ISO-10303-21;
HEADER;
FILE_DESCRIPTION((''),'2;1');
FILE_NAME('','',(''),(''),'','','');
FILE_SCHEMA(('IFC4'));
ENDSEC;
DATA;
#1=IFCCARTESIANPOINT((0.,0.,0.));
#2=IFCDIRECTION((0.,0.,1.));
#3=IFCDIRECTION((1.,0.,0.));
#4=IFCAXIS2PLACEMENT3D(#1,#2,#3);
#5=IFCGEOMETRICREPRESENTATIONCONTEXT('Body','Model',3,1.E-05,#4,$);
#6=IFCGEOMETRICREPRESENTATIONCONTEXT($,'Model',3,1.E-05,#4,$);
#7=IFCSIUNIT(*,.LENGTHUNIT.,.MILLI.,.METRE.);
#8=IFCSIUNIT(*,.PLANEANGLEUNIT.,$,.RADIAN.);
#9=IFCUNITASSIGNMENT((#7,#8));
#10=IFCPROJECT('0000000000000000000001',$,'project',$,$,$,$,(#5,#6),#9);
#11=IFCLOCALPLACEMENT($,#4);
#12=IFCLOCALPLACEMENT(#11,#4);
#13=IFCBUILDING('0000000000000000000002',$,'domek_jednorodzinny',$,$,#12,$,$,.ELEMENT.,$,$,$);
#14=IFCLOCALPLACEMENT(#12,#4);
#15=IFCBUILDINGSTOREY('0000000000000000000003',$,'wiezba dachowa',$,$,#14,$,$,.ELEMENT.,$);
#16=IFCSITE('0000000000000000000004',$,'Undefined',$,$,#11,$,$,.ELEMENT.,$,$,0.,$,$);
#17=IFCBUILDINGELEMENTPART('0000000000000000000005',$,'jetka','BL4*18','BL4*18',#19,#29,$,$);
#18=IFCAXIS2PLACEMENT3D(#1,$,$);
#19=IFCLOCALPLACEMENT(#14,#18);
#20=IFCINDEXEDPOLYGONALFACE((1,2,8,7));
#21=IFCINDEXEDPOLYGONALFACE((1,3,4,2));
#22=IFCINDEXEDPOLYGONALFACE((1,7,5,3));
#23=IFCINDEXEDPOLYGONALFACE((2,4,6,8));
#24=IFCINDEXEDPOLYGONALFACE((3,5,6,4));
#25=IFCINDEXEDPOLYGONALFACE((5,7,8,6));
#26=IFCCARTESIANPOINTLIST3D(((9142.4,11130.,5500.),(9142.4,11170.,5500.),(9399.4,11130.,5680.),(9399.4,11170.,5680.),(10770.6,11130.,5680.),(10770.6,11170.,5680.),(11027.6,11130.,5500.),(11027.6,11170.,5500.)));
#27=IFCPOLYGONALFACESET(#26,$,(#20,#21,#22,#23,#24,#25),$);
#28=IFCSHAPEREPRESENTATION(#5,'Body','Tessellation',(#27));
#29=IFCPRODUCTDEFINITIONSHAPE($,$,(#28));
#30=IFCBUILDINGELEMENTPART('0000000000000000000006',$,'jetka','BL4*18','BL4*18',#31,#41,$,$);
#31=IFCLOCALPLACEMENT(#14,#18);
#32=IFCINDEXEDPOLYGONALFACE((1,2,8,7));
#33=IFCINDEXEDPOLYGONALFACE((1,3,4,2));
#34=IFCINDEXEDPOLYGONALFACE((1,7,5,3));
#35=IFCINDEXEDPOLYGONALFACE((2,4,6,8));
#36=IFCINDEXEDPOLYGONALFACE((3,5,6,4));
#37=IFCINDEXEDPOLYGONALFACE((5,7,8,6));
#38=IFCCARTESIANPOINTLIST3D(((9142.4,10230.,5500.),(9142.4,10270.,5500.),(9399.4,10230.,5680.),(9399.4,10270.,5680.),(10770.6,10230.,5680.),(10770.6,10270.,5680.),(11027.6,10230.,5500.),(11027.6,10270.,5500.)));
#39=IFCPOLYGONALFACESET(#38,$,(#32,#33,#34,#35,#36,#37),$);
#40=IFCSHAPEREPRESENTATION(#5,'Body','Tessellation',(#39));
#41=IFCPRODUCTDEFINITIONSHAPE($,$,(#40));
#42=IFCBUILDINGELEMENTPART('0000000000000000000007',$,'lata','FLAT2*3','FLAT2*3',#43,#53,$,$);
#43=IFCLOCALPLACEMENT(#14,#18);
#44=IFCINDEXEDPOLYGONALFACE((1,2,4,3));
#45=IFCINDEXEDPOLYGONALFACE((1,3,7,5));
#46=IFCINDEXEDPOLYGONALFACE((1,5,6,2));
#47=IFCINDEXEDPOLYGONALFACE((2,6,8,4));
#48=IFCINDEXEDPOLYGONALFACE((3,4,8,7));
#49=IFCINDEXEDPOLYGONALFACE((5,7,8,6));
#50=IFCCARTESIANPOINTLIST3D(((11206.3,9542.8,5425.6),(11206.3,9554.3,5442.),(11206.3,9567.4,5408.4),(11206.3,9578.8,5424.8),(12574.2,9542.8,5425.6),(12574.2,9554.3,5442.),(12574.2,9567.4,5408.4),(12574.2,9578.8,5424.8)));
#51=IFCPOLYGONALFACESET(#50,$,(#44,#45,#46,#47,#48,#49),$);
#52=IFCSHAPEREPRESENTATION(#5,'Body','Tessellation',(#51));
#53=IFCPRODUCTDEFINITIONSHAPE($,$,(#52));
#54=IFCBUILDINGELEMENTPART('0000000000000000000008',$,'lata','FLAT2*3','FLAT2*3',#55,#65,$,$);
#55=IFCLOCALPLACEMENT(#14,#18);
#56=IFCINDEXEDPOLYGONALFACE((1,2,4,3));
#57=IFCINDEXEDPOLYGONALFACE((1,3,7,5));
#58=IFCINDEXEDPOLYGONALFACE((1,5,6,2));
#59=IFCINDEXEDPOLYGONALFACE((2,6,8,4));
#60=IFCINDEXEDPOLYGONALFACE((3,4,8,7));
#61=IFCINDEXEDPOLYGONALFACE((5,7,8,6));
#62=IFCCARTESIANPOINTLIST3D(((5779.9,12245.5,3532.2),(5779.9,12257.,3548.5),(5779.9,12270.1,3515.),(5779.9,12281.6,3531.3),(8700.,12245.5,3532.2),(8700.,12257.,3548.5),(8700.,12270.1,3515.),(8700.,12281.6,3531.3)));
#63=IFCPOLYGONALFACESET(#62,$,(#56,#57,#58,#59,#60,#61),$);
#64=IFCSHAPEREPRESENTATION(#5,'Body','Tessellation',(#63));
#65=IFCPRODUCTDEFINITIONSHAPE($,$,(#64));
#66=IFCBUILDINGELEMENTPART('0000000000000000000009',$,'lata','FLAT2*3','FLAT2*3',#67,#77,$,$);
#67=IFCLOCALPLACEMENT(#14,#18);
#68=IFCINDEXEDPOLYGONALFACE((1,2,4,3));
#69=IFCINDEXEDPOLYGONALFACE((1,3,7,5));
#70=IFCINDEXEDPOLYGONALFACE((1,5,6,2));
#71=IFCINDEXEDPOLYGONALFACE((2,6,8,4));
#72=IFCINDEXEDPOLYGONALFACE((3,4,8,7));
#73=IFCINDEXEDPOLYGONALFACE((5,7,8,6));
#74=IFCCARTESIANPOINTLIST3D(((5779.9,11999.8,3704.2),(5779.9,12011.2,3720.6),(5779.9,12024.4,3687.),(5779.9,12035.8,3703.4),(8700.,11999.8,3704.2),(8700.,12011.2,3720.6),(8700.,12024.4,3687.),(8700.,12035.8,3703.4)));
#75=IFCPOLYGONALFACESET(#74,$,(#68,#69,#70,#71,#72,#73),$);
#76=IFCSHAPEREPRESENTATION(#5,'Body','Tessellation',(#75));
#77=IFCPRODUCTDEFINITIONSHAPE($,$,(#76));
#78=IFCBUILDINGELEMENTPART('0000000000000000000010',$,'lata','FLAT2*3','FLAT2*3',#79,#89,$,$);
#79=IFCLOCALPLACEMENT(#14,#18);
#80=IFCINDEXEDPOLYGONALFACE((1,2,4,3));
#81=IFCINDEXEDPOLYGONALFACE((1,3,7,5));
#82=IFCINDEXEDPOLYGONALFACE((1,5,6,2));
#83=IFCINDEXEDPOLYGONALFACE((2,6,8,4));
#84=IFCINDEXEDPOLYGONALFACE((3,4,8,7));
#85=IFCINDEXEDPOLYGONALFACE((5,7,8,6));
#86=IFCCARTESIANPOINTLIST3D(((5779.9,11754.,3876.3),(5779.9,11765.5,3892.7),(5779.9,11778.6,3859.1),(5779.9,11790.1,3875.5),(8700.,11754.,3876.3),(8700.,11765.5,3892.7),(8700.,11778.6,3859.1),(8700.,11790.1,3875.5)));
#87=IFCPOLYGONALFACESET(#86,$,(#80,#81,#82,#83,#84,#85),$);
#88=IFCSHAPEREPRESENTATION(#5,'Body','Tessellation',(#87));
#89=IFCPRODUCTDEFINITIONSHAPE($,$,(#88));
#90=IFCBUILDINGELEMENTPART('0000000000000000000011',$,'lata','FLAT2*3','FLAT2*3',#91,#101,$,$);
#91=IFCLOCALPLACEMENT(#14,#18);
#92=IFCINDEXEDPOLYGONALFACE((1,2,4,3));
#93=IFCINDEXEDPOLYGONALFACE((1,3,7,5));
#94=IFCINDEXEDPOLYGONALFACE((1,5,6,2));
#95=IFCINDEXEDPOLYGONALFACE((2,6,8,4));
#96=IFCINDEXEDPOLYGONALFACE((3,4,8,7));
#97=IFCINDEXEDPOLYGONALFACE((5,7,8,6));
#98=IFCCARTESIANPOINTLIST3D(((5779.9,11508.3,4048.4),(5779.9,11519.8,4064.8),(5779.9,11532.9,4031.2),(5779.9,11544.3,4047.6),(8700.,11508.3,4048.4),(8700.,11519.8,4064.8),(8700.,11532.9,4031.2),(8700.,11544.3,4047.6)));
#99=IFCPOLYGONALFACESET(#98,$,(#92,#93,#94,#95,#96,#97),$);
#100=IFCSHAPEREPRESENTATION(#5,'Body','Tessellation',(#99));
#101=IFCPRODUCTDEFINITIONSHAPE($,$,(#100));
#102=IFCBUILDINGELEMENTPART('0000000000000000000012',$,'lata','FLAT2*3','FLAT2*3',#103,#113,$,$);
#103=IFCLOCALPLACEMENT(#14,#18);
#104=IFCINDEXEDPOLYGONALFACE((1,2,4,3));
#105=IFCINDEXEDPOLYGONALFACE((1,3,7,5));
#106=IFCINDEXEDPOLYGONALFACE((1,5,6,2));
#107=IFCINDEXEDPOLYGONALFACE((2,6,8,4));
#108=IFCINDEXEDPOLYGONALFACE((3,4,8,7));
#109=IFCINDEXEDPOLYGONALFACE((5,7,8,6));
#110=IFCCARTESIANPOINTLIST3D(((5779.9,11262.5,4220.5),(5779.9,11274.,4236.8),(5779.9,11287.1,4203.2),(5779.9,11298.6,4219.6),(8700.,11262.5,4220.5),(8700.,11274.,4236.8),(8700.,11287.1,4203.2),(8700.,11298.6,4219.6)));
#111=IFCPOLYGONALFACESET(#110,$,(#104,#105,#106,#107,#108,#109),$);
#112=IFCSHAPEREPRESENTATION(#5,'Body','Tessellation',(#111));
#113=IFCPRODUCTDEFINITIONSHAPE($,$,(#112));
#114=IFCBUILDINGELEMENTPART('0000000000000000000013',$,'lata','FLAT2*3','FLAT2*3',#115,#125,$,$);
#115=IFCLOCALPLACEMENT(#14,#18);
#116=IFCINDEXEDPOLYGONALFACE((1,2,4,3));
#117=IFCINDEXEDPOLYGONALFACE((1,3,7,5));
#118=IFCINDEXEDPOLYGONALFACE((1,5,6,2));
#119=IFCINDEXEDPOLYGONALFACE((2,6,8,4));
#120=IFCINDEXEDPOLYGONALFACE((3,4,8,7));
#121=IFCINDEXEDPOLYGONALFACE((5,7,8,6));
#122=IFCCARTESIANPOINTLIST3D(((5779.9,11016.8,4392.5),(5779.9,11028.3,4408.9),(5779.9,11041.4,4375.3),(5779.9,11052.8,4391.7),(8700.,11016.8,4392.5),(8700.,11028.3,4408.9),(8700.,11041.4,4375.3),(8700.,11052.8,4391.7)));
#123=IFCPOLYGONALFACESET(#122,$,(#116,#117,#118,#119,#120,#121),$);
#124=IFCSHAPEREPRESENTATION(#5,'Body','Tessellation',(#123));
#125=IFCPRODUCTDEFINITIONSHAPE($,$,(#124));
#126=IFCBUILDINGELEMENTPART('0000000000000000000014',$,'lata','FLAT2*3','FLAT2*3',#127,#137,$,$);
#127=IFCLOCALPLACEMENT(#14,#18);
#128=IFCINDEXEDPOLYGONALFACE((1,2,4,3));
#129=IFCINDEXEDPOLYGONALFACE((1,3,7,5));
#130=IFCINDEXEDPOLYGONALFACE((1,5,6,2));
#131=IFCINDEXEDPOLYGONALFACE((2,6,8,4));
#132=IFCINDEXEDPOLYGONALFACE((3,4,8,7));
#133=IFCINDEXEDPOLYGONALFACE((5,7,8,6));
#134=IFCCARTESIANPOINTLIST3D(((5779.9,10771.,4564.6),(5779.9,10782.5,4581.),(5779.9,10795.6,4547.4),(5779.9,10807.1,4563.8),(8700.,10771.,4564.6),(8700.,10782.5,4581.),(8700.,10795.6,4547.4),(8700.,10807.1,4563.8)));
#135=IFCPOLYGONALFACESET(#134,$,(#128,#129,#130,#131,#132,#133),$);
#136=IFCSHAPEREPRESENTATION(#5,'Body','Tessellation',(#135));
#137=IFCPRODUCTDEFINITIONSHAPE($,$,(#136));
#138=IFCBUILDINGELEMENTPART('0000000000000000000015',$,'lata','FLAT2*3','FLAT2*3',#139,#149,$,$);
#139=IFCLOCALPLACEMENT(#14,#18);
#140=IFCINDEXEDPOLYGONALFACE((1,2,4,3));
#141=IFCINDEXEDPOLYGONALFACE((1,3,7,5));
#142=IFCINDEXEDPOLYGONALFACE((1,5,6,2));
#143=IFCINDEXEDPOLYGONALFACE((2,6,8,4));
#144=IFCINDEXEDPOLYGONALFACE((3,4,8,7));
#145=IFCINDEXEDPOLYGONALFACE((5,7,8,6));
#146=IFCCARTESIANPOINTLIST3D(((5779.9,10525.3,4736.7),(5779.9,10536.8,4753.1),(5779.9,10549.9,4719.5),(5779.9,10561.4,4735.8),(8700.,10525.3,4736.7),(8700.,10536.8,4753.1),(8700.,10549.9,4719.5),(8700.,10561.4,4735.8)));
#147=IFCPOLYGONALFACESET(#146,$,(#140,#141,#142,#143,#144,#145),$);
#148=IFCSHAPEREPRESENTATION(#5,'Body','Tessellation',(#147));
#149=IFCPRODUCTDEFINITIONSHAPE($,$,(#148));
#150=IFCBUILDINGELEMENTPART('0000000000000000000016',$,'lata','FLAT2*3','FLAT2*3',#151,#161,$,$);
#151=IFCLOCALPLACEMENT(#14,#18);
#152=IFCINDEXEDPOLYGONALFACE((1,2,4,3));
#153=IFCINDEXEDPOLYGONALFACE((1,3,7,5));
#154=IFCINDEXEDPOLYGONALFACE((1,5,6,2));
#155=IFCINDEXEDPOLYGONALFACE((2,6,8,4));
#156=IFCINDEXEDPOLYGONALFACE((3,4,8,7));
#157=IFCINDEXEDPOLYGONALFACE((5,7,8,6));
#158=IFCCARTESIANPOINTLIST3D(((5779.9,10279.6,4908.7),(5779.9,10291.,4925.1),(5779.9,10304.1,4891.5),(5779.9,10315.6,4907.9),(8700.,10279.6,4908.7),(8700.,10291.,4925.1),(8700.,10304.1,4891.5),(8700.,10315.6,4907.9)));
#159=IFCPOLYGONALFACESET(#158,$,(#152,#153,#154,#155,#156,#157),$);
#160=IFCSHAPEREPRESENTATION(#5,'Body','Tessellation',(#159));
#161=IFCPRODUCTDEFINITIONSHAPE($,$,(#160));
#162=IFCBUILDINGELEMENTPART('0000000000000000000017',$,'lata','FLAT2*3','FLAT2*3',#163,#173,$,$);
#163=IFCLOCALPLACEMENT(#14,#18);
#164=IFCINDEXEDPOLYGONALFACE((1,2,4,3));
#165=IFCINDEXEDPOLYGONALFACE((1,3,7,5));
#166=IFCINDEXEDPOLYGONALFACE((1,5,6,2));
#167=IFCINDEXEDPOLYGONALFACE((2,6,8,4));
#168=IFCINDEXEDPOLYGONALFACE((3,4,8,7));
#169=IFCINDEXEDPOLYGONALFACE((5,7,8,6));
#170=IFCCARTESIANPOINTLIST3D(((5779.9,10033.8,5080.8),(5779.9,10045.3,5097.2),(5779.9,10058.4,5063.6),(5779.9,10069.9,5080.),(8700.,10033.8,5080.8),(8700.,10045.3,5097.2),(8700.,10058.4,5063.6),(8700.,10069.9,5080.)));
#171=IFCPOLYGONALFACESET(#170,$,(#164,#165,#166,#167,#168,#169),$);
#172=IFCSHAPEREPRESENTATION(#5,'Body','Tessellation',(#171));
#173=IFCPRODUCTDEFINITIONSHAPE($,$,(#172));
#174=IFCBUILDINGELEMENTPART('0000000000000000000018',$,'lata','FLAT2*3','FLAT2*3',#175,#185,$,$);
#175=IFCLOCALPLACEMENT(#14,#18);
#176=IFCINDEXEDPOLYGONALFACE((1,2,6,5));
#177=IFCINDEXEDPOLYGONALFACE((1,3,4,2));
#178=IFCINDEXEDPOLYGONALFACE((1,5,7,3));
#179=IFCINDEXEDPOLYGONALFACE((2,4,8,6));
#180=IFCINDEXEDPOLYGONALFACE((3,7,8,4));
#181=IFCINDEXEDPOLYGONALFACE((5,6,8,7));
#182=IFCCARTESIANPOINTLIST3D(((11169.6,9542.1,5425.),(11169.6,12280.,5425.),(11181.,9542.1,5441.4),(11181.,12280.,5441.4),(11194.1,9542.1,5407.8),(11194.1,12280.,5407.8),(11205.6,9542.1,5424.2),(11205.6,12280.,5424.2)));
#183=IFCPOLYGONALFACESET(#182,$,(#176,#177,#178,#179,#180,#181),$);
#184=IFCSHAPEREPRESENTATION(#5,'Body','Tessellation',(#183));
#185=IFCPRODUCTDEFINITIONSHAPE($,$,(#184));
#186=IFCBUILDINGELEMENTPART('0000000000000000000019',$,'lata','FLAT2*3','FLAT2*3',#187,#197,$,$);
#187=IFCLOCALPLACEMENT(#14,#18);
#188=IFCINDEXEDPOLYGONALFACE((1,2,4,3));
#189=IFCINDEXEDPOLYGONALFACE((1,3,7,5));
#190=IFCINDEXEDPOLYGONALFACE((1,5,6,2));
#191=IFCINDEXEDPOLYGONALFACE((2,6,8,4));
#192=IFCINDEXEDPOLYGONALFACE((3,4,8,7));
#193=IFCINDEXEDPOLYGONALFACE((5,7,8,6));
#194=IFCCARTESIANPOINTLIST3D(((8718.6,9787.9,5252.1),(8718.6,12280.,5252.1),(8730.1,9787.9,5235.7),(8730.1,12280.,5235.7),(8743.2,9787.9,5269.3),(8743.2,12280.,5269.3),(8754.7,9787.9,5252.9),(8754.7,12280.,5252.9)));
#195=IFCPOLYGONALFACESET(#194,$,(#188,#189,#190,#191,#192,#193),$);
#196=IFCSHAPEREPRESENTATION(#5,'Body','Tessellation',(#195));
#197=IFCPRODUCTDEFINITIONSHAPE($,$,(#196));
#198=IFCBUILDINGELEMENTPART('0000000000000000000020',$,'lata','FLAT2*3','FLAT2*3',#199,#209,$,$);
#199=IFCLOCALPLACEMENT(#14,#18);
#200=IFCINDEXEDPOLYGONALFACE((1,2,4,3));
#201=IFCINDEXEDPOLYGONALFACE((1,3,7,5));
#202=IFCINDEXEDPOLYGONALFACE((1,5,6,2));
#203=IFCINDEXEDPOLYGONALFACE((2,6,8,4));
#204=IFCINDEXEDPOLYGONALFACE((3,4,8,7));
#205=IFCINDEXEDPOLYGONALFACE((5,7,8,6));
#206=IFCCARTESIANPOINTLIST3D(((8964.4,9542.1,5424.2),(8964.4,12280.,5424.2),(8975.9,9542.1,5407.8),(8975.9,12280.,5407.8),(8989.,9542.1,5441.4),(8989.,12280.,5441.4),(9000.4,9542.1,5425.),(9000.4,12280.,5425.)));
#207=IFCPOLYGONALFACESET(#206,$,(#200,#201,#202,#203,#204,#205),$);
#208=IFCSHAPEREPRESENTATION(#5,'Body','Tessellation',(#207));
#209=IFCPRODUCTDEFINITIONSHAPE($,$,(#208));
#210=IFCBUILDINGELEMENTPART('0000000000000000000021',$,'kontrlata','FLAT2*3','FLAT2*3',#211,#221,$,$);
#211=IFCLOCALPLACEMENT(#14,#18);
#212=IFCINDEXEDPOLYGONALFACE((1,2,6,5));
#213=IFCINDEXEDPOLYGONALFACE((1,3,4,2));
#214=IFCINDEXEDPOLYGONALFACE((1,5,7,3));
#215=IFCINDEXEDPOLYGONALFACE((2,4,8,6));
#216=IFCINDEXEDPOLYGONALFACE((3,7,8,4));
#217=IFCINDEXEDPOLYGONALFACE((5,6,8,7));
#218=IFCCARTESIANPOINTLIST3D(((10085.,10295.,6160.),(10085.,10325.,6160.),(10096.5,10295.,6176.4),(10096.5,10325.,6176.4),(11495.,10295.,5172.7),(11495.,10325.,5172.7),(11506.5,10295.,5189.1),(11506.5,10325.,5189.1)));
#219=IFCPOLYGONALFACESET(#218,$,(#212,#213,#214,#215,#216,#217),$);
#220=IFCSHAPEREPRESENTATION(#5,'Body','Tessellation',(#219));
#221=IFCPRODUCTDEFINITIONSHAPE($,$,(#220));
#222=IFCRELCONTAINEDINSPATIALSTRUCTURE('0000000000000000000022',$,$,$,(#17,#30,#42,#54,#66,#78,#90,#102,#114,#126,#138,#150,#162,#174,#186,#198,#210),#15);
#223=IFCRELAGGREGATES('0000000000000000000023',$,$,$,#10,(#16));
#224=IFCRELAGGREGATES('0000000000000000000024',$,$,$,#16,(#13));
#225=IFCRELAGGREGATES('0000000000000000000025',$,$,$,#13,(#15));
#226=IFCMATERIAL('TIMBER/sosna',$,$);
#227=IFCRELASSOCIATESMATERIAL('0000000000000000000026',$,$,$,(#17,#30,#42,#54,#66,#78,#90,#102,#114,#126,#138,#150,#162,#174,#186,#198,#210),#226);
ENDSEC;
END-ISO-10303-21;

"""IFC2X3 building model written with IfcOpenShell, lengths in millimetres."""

from ifc_helpers import new_model, si_unit, frame, origin_with_axes, origin_2d_with_axis, place, context, project, spatial, rectangle, extrude, clip, halfspace, material, element, save


model = new_model("IFC2X3")

# Units and contexts
model_context_1 = context("Model", 3, precision=1e-05, world=origin_with_axes(), identifier="Body")
model_context_2 = context("Model", 3, precision=1e-05, world=origin_with_axes())
ifc_project = project(units=[si_unit("LENGTHUNIT", "METRE", prefix="MILLI"), si_unit("PLANEANGLEUNIT", "RADIAN")], contexts=[model_context_1, model_context_2])

# Site, building, storey
site_placement = place(None, origin_with_axes())
site = spatial("IfcSite", under=ifc_project, at=site_placement, Name="Undefined", CompositionType="ELEMENT", RefElevation=0.0)
building_placement = place(site_placement, origin_with_axes())
building = spatial("IfcBuilding", under=site, at=building_placement, Name="domek_jednorodzinny", CompositionType="ELEMENT")
storey_placement = place(building_placement, origin_with_axes())
storey = spatial("IfcBuildingStorey", under=building, at=storey_placement, Name="wiezba dachowa", CompositionType="ELEMENT")

# Building element parts
ifc_material = material(Name="TIMBER/sosna")
building_element_part_1_placement = place(storey_placement, frame((9142.4, 11150.0, 5590.0), z_axis=(0.0, 0.0, 1.0), x_axis=(1.0, 0.0, 0.0)))
element("IfcBuildingElementPart", 1, at=building_element_part_1_placement, inside=storey, material=ifc_material, Name="jetka", Description="BL4*18", ObjectType="BL4*18", context=model_context_1, shape_type="Clipping", body=[
    clip(clip(extrude(rectangle(XDim=40.0, YDim=180.0, at=origin_2d_with_axis()), frame((1885.2, 0.0, 0.0), z_axis=(-1.0, 0.0, 0.0), x_axis=(0.0, -1.0, 0.0)), (0.0, 0.0, 1.0), 1885.2), halfspace(frame((1885.2, 40.0, -90.0), z_axis=(0.573578, 0.0, 0.819151), x_axis=(0.0, -1.0, 0.0)), False)), halfspace(frame((0.0, -40.0, -90.0), z_axis=(-0.573576, 0.0, 0.819152), x_axis=(0.0, 1.0, 0.0)), False)),
])
building_element_part_2_placement = place(storey_placement, frame((9142.4, 10250.0, 5590.0), z_axis=(0.0, 0.0, 1.0), x_axis=(1.0, 0.0, 0.0)))
element("IfcBuildingElementPart", 2, at=building_element_part_2_placement, inside=storey, material=ifc_material, Name="jetka", Description="BL4*18", ObjectType="BL4*18", context=model_context_1, shape_type="Clipping", body=[
    clip(clip(extrude(rectangle(XDim=40.0, YDim=180.0, at=origin_2d_with_axis()), frame((1885.2, 0.0, 0.0), z_axis=(-1.0, 0.0, 0.0), x_axis=(0.0, -1.0, 0.0)), (0.0, 0.0, 1.0), 1885.2), halfspace(frame((1885.2, 40.0, -90.0), z_axis=(0.573578, 0.0, 0.819151), x_axis=(0.0, -1.0, 0.0)), False)), halfspace(frame((0.0, -40.0, -90.0), z_axis=(-0.573576, 0.0, 0.819152), x_axis=(0.0, 1.0, 0.0)), False)),
])
building_element_part_3_placement = place(storey_placement, frame((11206.3, 9560.8, 5425.2), z_axis=(0.0, -0.819154, 0.573574), x_axis=(1.0, 0.0, 0.0)))
element("IfcBuildingElementPart", 3, at=building_element_part_3_placement, inside=storey, material=ifc_material, Name="lata", Description="FLAT2*3", ObjectType="FLAT2*3", context=model_context_1, shape_type="SweptSolid", body=[
    extrude(rectangle(XDim=20.0, YDim=30.0, at=origin_2d_with_axis()), frame((1368.0, 0.0, 0.0), z_axis=(-1.0, 0.0, 0.0), x_axis=(0.0, -1.0, 0.0)), (0.0, 0.0, 1.0), 1368.0),
])
for number, where, z_axis, x_axis, name in (
    (4, (5779.9, 12263.5, 3531.7), (0.0, -0.819154, 0.573574), (1.0, 0.0, 0.0), "lata"),
    (5, (5779.9, 12017.8, 3703.8), (0.0, -0.819154, 0.573574), (1.0, 0.0, 0.0), "lata"),
    (6, (5779.9, 11772.1, 3875.9), (0.0, -0.819154, 0.573574), (1.0, 0.0, 0.0), "lata"),
    (7, (5779.9, 11526.3, 4048.0), (0.0, -0.819154, 0.573574), (1.0, 0.0, 0.0), "lata"),
    (8, (5779.9, 11280.6, 4220.0), (0.0, -0.819154, 0.573574), (1.0, 0.0, 0.0), "lata"),
    (9, (5779.9, 11034.8, 4392.1), (0.0, -0.819154, 0.573574), (1.0, 0.0, 0.0), "lata"),
    (10, (5779.9, 10789.1, 4564.2), (0.0, -0.819154, 0.573574), (1.0, 0.0, 0.0), "lata"),
    (11, (5779.9, 10543.3, 4736.3), (0.0, -0.819154, 0.573574), (1.0, 0.0, 0.0), "lata"),
    (12, (5779.9, 10297.6, 4908.3), (0.0, -0.819154, 0.573574), (1.0, 0.0, 0.0), "lata"),
    (13, (5779.9, 10051.8, 5080.4), (0.0, -0.819154, 0.573574), (1.0, 0.0, 0.0), "lata"),
):
    element("IfcBuildingElementPart", number, at=place(storey_placement, frame(where, z_axis=z_axis, x_axis=x_axis)), inside=storey, material=ifc_material, Name=name, Description="FLAT2*3", ObjectType="FLAT2*3", context=model_context_1, shape_type="SweptSolid", body=[
        extrude(rectangle(XDim=20.0, YDim=30.0, at=origin_2d_with_axis()), frame((2920.0, 0.0, 0.0), z_axis=(-1.0, 0.0, 0.0), x_axis=(0.0, -1.0, 0.0)), (0.0, 0.0, 1.0), 2920.0),
    ])
building_element_part_4_placement = place(storey_placement, frame((11187.6, 9542.1, 5424.6), z_axis=(-0.819152, 0.0, 0.573576), x_axis=(0.0, 1.0, 0.0)))
element("IfcBuildingElementPart", 14, at=building_element_part_4_placement, inside=storey, material=ifc_material, Name="lata", Description="FLAT2*3", ObjectType="FLAT2*3", context=model_context_1, shape_type="SweptSolid", body=[
    extrude(rectangle(XDim=20.0, YDim=30.0, at=origin_2d_with_axis()), frame((2737.8, 0.0, 0.0), z_axis=(-1.0, 0.0, 0.0), x_axis=(0.0, -1.0, 0.0)), (0.0, 0.0, 1.0), 2737.8),
])
building_element_part_5_placement = place(storey_placement, frame((8736.7, 9787.9, 5252.5), z_axis=(0.819152, 0.0, 0.573576), x_axis=(0.0, 1.0, 0.0)))
element("IfcBuildingElementPart", 15, at=building_element_part_5_placement, inside=storey, material=ifc_material, Name="lata", Description="FLAT2*3", ObjectType="FLAT2*3", context=model_context_1, shape_type="SweptSolid", body=[
    extrude(rectangle(XDim=20.0, YDim=30.0, at=origin_2d_with_axis()), frame((2492.1, 0.0, 0.0), z_axis=(-1.0, 0.0, 0.0), x_axis=(0.0, -1.0, 0.0)), (0.0, 0.0, 1.0), 2492.1),
])
building_element_part_6_placement = place(storey_placement, frame((8982.4, 9542.1, 5424.6), z_axis=(0.819152, 0.0, 0.573576), x_axis=(0.0, 1.0, 0.0)))
element("IfcBuildingElementPart", 16, at=building_element_part_6_placement, inside=storey, material=ifc_material, Name="lata", Description="FLAT2*3", ObjectType="FLAT2*3", context=model_context_1, shape_type="SweptSolid", body=[
    extrude(rectangle(XDim=20.0, YDim=30.0, at=origin_2d_with_axis()), frame((2737.8, 0.0, 0.0), z_axis=(-1.0, 0.0, 0.0), x_axis=(0.0, -1.0, 0.0)), (0.0, 0.0, 1.0), 2737.8),
])
building_element_part_7_placement = place(storey_placement, frame((10090.7, 10310.0, 6168.2), z_axis=(0.0, -1.0, 0.0), x_axis=(0.819151, 0.0, -0.573578)))
element("IfcBuildingElementPart", 17, at=building_element_part_7_placement, inside=storey, material=ifc_material, Name="kontrlata", Description="FLAT2*3", ObjectType="FLAT2*3", context=model_context_1, shape_type="SweptSolid", body=[
    extrude(rectangle(XDim=20.0, YDim=30.0, at=origin_2d_with_axis()), frame((1721.3, 0.0, 0.0), z_axis=(-1.0, 0.0, 0.0), x_axis=(0.0, -1.0, 0.0)), (0.0, 0.0, 1.0), 1721.3),
])

save(model, "model.ifc")
